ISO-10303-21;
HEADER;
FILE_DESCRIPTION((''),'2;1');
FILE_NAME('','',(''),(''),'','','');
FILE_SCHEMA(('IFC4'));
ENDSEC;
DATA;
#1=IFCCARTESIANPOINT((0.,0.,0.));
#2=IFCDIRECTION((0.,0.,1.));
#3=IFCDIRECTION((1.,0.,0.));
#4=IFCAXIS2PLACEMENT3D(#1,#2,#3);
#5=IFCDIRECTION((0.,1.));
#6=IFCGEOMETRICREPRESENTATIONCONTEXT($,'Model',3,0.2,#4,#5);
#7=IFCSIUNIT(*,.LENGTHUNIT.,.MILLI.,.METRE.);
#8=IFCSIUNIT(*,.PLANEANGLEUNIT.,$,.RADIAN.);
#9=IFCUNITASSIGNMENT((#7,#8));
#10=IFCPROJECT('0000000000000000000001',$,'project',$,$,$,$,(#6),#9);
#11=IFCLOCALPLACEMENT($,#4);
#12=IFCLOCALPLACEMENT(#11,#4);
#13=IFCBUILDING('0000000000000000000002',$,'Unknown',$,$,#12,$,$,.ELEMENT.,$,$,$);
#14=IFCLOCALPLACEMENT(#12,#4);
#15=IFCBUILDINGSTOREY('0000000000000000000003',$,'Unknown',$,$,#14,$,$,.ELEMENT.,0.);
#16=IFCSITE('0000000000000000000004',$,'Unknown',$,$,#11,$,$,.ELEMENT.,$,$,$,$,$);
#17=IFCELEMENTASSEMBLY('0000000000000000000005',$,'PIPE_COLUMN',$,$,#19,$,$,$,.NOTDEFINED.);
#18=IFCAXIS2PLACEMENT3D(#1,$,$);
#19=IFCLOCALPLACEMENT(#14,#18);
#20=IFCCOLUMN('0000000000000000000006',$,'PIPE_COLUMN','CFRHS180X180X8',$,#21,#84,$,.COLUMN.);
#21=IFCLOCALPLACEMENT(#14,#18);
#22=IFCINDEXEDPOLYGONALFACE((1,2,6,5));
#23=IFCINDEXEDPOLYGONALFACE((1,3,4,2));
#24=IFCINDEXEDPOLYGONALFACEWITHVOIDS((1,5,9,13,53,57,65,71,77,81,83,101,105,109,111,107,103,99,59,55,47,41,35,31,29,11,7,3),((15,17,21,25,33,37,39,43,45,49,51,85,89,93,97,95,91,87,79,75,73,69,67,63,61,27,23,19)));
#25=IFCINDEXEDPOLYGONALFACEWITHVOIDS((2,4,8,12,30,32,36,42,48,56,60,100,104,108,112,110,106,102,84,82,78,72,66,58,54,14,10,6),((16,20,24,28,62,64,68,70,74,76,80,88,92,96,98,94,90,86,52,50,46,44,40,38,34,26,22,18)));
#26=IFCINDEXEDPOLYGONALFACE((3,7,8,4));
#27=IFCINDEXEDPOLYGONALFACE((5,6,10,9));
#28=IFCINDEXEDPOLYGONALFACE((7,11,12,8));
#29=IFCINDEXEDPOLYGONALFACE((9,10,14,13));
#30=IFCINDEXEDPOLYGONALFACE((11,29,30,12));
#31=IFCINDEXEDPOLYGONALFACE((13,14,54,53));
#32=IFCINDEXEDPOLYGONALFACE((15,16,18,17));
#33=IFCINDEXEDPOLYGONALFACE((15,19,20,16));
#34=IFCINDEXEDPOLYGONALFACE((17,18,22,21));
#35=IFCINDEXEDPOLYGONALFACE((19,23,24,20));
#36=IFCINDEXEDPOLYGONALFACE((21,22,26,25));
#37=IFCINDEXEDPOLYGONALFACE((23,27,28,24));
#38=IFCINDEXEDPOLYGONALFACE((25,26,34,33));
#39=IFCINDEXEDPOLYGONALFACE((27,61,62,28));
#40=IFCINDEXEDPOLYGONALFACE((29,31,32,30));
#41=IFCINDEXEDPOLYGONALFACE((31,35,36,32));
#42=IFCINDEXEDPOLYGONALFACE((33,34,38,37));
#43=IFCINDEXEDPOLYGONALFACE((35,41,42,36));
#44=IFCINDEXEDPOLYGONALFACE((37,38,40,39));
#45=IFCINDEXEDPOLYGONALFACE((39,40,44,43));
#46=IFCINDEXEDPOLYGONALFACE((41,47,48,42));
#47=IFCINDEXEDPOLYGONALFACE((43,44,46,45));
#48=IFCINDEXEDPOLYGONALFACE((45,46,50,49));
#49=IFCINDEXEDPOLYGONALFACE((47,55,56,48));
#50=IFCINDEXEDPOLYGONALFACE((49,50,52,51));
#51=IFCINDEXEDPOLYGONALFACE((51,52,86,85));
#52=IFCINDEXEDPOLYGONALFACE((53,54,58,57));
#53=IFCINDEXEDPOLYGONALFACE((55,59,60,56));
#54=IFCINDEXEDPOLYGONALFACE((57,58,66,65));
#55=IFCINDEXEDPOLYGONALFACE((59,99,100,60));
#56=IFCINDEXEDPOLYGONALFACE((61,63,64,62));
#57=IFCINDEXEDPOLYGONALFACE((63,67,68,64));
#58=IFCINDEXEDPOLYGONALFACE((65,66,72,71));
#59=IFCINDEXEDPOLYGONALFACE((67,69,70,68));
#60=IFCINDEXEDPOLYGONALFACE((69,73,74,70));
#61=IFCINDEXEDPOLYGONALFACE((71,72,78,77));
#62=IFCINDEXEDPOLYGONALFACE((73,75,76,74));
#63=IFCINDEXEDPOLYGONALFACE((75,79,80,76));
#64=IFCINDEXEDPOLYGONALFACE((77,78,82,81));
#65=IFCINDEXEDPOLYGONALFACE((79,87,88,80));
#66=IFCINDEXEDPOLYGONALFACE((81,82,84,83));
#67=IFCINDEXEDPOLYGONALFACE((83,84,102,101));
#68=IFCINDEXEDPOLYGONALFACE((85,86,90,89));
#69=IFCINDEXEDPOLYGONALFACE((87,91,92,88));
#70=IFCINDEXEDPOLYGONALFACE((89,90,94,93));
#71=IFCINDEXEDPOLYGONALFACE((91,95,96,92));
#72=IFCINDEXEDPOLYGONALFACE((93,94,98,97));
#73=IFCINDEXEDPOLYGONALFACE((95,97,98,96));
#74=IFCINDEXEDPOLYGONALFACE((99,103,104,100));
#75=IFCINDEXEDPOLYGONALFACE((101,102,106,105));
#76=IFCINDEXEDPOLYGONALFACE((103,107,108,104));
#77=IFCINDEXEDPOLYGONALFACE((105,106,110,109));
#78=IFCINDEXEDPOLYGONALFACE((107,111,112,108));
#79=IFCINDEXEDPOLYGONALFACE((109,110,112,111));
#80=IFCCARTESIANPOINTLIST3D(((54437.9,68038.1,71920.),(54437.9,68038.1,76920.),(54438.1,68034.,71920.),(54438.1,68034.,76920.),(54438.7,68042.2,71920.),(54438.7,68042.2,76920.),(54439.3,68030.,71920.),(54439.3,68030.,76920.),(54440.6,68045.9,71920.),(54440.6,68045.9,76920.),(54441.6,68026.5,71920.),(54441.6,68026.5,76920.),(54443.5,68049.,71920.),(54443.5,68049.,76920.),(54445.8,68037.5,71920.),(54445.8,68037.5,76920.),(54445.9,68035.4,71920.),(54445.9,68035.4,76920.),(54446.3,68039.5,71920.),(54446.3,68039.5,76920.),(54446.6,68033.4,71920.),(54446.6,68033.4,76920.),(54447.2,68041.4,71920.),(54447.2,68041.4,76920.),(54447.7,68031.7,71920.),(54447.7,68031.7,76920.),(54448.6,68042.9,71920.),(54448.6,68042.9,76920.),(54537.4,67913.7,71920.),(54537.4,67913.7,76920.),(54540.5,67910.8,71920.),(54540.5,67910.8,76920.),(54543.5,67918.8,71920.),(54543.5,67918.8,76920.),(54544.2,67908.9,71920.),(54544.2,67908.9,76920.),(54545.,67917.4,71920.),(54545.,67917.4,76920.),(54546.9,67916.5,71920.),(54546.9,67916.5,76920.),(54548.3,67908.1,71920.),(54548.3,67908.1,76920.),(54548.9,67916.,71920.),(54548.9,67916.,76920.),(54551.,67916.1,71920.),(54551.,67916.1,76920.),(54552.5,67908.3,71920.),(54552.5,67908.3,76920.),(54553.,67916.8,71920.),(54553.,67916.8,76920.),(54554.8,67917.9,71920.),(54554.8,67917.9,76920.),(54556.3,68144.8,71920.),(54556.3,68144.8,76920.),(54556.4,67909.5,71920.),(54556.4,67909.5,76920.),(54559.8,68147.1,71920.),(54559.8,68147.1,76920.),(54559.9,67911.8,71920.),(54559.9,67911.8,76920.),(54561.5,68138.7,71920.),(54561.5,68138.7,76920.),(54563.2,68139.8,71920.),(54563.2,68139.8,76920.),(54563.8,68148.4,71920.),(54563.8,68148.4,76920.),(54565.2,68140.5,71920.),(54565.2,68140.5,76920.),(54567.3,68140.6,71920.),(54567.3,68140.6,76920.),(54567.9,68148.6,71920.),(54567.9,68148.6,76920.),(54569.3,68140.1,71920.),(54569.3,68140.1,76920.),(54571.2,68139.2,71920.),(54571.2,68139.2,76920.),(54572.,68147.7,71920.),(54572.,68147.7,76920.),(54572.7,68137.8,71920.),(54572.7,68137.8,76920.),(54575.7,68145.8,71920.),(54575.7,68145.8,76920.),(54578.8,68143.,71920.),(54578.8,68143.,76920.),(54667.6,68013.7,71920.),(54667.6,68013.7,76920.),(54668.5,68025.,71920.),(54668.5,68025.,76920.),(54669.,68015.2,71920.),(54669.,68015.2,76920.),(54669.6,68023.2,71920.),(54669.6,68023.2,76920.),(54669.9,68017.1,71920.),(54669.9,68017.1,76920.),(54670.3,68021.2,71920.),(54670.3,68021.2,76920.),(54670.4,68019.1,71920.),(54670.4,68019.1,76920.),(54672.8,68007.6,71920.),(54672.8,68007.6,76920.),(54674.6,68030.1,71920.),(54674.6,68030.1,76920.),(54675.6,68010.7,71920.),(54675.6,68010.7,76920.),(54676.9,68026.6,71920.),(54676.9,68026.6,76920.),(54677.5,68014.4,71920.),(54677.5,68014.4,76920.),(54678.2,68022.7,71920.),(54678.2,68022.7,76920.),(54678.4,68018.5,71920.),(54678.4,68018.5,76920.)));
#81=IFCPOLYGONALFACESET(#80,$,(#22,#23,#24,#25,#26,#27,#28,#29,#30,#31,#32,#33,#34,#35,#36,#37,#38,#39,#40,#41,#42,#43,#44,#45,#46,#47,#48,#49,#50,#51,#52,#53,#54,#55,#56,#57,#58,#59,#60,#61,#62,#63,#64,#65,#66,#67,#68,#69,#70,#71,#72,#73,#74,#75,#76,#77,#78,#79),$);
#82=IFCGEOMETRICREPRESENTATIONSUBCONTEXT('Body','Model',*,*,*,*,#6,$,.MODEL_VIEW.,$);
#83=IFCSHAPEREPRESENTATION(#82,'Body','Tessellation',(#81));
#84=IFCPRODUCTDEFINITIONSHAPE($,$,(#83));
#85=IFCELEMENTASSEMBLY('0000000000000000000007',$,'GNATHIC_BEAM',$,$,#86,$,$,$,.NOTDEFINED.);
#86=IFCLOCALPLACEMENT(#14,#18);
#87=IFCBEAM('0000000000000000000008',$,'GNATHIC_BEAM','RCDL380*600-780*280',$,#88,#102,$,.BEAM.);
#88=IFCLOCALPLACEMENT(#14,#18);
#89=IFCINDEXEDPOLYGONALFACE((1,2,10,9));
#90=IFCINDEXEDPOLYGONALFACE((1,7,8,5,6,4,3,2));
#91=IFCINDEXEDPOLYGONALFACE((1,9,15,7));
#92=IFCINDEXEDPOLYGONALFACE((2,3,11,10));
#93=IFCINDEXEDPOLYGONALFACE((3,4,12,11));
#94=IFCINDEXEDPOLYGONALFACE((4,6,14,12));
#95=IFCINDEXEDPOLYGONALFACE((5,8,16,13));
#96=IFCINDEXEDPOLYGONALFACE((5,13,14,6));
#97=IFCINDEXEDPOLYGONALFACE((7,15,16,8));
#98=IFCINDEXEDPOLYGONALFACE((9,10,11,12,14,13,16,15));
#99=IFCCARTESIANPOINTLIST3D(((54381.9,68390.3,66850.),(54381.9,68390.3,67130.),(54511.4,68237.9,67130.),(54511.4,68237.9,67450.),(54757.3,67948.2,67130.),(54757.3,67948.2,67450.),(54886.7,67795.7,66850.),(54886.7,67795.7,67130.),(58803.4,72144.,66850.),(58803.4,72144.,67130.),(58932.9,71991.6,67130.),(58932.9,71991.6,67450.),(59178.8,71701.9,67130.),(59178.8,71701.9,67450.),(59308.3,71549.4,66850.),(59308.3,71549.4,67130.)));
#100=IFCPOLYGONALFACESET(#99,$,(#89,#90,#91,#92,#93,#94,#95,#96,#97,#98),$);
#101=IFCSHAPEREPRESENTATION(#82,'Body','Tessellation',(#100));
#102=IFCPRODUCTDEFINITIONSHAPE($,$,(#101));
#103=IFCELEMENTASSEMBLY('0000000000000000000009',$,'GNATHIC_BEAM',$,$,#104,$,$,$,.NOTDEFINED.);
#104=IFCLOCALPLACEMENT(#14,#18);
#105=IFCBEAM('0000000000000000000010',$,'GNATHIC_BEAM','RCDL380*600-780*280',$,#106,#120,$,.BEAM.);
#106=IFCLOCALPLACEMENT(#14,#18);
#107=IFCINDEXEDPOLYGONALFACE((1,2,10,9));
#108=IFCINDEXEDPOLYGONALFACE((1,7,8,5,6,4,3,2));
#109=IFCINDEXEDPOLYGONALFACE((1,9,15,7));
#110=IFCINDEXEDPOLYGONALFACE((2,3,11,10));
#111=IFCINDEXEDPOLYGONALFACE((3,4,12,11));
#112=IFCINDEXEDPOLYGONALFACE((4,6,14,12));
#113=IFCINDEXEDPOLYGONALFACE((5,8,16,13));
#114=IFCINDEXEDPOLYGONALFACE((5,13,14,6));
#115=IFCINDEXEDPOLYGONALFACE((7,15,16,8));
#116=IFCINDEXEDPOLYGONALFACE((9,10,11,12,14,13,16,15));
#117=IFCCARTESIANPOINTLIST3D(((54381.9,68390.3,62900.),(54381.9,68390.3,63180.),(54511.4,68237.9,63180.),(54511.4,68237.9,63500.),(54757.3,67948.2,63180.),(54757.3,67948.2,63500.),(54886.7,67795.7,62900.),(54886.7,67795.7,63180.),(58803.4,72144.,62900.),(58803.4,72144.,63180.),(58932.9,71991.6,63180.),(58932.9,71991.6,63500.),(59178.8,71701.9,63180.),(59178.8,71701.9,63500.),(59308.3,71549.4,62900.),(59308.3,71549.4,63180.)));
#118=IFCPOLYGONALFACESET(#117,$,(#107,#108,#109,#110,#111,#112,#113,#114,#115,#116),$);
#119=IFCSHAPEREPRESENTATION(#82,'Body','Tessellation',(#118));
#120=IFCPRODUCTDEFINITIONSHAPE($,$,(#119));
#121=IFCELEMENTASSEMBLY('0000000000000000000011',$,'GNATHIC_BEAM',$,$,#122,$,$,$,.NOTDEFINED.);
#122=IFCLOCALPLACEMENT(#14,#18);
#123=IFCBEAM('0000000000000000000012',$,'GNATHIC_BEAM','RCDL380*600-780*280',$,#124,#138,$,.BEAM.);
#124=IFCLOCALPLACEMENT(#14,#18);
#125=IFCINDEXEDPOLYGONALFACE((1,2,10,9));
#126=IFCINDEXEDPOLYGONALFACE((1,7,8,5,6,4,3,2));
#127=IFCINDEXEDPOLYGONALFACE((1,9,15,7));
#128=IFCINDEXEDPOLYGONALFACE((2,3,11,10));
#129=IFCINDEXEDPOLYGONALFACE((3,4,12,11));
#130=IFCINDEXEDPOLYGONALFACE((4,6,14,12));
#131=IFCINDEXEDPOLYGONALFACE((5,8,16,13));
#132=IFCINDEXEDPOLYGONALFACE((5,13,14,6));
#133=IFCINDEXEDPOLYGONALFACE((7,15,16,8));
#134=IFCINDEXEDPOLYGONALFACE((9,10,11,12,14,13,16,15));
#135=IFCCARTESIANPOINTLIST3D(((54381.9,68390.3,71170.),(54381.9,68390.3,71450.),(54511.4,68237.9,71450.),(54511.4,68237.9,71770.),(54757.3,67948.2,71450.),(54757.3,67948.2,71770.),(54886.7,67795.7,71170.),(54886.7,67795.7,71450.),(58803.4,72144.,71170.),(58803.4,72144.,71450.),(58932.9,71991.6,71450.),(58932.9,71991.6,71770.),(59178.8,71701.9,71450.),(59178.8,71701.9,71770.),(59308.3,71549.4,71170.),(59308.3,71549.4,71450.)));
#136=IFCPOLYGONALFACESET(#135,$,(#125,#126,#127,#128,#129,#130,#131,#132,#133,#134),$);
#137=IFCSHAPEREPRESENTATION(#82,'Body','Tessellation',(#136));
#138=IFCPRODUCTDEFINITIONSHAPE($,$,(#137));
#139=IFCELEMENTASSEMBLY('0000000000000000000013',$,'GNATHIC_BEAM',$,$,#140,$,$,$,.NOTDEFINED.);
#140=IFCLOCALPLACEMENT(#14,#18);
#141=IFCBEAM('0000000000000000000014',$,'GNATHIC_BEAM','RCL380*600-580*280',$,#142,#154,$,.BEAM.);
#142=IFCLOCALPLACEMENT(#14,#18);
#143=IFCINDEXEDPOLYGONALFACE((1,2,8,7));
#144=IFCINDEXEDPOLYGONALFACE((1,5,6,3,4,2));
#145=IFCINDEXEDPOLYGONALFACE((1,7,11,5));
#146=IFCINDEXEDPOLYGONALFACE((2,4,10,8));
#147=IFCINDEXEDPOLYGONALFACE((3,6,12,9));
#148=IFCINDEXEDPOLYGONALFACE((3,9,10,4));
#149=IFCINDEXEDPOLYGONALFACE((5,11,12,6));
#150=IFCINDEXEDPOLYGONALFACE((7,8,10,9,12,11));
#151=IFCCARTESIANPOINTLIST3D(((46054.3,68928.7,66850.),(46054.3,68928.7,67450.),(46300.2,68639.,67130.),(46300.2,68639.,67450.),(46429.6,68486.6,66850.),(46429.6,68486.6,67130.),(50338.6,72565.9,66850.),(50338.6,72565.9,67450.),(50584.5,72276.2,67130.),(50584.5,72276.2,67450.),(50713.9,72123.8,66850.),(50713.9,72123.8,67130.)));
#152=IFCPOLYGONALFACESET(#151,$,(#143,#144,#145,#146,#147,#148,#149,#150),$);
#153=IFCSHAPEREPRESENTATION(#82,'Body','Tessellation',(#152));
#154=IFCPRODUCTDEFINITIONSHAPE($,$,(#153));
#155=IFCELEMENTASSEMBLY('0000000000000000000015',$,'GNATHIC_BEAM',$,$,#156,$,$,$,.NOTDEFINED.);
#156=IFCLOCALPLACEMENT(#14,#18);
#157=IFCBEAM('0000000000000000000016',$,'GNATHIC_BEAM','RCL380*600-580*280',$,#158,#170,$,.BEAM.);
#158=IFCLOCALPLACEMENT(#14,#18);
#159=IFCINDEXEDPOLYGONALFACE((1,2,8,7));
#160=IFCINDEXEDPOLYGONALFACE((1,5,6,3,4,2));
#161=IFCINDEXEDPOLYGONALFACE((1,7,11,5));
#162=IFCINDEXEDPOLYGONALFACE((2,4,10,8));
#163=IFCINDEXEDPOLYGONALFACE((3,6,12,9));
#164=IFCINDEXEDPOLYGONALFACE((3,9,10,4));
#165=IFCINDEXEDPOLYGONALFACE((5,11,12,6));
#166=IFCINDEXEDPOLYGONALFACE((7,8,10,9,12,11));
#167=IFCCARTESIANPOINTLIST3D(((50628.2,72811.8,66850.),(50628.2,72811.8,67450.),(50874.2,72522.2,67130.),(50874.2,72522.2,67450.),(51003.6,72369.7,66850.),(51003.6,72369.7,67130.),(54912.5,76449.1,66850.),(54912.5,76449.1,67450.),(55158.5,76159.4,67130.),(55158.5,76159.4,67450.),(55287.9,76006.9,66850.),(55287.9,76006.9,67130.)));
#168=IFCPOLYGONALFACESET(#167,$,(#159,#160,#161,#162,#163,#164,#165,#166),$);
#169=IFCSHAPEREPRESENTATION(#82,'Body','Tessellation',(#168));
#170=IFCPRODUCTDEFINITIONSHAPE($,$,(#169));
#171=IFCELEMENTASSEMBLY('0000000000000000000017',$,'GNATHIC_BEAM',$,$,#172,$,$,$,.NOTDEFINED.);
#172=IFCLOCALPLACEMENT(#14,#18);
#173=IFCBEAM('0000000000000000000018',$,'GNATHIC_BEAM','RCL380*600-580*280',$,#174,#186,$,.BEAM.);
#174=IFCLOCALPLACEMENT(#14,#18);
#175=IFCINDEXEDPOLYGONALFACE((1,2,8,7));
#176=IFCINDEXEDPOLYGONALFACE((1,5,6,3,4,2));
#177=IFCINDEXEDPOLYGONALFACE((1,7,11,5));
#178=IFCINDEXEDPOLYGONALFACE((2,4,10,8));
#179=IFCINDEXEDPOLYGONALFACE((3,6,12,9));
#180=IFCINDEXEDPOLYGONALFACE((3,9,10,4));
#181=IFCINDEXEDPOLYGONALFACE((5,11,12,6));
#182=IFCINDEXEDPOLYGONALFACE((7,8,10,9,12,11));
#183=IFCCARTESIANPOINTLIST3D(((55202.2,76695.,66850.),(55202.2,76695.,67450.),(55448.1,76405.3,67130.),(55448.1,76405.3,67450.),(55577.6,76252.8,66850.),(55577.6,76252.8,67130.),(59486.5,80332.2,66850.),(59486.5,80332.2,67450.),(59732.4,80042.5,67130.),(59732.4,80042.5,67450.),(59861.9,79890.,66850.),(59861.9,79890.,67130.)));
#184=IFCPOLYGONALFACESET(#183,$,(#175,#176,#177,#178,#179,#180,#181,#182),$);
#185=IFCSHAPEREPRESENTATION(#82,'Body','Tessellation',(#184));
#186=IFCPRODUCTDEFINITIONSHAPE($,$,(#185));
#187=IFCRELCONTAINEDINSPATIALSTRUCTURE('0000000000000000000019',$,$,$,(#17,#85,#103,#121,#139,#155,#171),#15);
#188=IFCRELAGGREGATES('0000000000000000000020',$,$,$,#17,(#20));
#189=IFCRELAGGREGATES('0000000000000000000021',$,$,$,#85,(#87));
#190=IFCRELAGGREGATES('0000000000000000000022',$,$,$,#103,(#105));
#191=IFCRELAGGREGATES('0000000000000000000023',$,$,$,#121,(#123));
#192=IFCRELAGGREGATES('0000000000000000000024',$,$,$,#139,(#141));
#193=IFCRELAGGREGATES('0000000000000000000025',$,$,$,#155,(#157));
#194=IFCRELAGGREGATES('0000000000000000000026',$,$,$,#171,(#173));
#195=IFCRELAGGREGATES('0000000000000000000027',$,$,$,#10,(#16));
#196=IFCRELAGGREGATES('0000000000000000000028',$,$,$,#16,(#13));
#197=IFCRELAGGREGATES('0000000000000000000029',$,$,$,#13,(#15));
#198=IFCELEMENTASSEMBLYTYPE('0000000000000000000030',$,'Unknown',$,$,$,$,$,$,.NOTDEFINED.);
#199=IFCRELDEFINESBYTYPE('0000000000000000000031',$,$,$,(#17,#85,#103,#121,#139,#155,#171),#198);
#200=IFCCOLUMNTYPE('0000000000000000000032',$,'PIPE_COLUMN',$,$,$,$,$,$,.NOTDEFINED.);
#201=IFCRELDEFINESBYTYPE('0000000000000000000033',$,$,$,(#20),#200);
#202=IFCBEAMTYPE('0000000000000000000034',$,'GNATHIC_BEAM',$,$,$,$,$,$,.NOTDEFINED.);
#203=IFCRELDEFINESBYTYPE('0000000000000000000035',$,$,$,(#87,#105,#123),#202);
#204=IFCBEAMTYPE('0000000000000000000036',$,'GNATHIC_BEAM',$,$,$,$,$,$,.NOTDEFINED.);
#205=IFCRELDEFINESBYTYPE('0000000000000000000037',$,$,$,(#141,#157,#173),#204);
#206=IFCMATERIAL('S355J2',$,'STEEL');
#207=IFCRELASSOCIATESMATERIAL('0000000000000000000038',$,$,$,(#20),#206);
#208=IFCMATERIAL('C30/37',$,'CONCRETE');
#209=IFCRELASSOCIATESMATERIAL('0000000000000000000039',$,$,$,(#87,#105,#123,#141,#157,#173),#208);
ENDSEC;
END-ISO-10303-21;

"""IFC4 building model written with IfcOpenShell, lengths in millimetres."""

from ifc_helpers import new_model, si_unit, direction, frame, origin_with_axes, origin_2d_with_axis, place, context, subcontext, project, spatial, polyline, hollow_rectangle, outline, extrude, material, material_profile, profile_set, profile_usage, type_object, element, aggregate, save


model = new_model("IFC4")

# Units and contexts
model_context = context("Model", 3, precision=0.2, world=origin_with_axes(), true_north=direction((0.0, 1.0)))
body_context = subcontext(model_context, "Body", "Model", "MODEL_VIEW")
ifc_project = project(units=[si_unit("LENGTHUNIT", "METRE", prefix="MILLI"), si_unit("PLANEANGLEUNIT", "RADIAN")], contexts=[model_context])

# Site, building, storey
site_placement = place(None, origin_with_axes())
site = spatial("IfcSite", under=ifc_project, at=site_placement, Name="Unknown", CompositionType="ELEMENT")
building_placement = place(site_placement, origin_with_axes())
building = spatial("IfcBuilding", under=site, at=building_placement, Name="Unknown", CompositionType="ELEMENT")
storey_placement = place(building_placement, origin_with_axes())
storey = spatial("IfcBuildingStorey", under=building, at=storey_placement, Name="Unknown", CompositionType="ELEMENT", Elevation=0.0)

# Element assembly, column
element_assembly_type = type_object("IfcElementAssemblyType", Name="Unknown", PredefinedType="NOTDEFINED")
ifc_material_1 = material(Name="S355J2", Category="STEEL")
ifc_material_profile_1 = material_profile(ifc_material_1, hollow_rectangle(XDim=180.0, YDim=180.0, WallThickness=8.0, InnerFilletRadius=8.0, OuterFilletRadius=16.0, at=origin_2d_with_axis()), Name="CFRHS180X180X8")
ifc_profile_set_1 = profile_set([ifc_material_profile_1])
column_type_1 = type_object("IfcColumnType", Name="PIPE_COLUMN")
assembly_1_placement = place(storey_placement, frame((54558.1, 68028.3, 71920.0), z_axis=(-0.762329, -0.64719, 0.0), x_axis=(0.0, 0.0, 1.0)))
assembly_1 = element("IfcElementAssembly", 1, at=assembly_1_placement, inside=storey, type_object=element_assembly_type, Name="PIPE_COLUMN", PredefinedType="NOTDEFINED")
ifc_profile_usage_1 = profile_usage(ifc_profile_set_1, cardinal=8)
column_1_placement = place(assembly_1_placement, origin_with_axes())
column_1 = element("IfcColumn", 2, at=column_1_placement, type_object=column_type_1, material=ifc_profile_usage_1, Name="PIPE_COLUMN", Description="CFRHS180X180X8", PredefinedType="COLUMN", context=body_context, shape_type="SolidModel", body=[
    extrude(hollow_rectangle(XDim=180.0, YDim=180.0, WallThickness=8.0, InnerFilletRadius=8.0, OuterFilletRadius=16.0, at=origin_2d_with_axis()), frame((0.0, 0.0, 0.0), z_axis=(-1.0, 0.0, 0.0), x_axis=(0.0, 0.0, 1.0)), (0.0, 0.0, -1.0), 5000.0),
])
aggregate(assembly_1, [column_1])

# Element assemblies, beams
assembly_2_placement = place(storey_placement, frame((54634.3, 68093.0, 67150.0), z_axis=(0.64719, -0.762329, 0.0), x_axis=(0.762329, 0.64719, 0.0)))
assembly_2 = element("IfcElementAssembly", 3, at=assembly_2_placement, inside=storey, type_object=element_assembly_type, Name="GNATHIC_BEAM", PredefinedType="NOTDEFINED")
ifc_material_2 = material(Name="C30/37", Category="CONCRETE")
ifc_material_profile_2 = material_profile(ifc_material_2, outline(polyline([(-390.0, -300.0), (390.0, -300.0), (390.0, -20.0), (190.0, -20.0), (190.0, 300.0), (-190.0, 300.0), (-190.0, -20.0), (-390.0, -20.0), (-390.0, -300.0)])), Name="RCDL380*600-780*280")
ifc_profile_set_2 = profile_set([ifc_material_profile_2])
ifc_profile_usage_2 = profile_usage(ifc_profile_set_2, cardinal=2)
beam_type_1 = type_object("IfcBeamType", Name="GNATHIC_BEAM")
beam_1_placement = place(assembly_2_placement, origin_with_axes())
beam_1 = element("IfcBeam", 4, at=beam_1_placement, type_object=beam_type_1, material=ifc_profile_usage_2, Name="GNATHIC_BEAM", Description="RCDL380*600-780*280", PredefinedType="BEAM", context=body_context, shape_type="SolidModel", body=[
    extrude(outline(polyline([(-390.0, -300.0), (390.0, -300.0), (390.0, -20.0), (190.0, -20.0), (190.0, 300.0), (-190.0, 300.0), (-190.0, -20.0), (-390.0, -20.0), (-390.0, -300.0)])), frame((0.0, 0.0, 0.0), z_axis=(-1.0, 0.0, 0.0), x_axis=(0.0, 0.0, 1.0)), (0.0, 0.0, -1.0), 5800.0),
])
aggregate(assembly_2, [beam_1])
assembly_3_placement = place(storey_placement, frame((54634.3, 68093.0, 63200.0), z_axis=(0.64719, -0.762329, 0.0), x_axis=(0.762329, 0.64719, 0.0)))
assembly_3 = element("IfcElementAssembly", 5, at=assembly_3_placement, inside=storey, type_object=element_assembly_type, Name="GNATHIC_BEAM", PredefinedType="NOTDEFINED")
beam_2_placement = place(assembly_3_placement, origin_with_axes())
beam_2 = element("IfcBeam", 6, at=beam_2_placement, type_object=beam_type_1, material=ifc_profile_usage_2, Name="GNATHIC_BEAM", Description="RCDL380*600-780*280", PredefinedType="BEAM", context=body_context, shape_type="SolidModel", body=[
    extrude(outline(polyline([(-390.0, -300.0), (390.0, -300.0), (390.0, -20.0), (190.0, -20.0), (190.0, 300.0), (-190.0, 300.0), (-190.0, -20.0), (-390.0, -20.0), (-390.0, -300.0)])), frame((0.0, 0.0, 0.0), z_axis=(-1.0, 0.0, 0.0), x_axis=(0.0, 0.0, 1.0)), (0.0, 0.0, -1.0), 5800.0),
])
aggregate(assembly_3, [beam_2])
assembly_4_placement = place(storey_placement, frame((54634.3, 68093.0, 71470.0), z_axis=(0.64719, -0.762329, 0.0), x_axis=(0.762329, 0.64719, 0.0)))
assembly_4 = element("IfcElementAssembly", 7, at=assembly_4_placement, inside=storey, type_object=element_assembly_type, Name="GNATHIC_BEAM", PredefinedType="NOTDEFINED")
beam_3_placement = place(assembly_4_placement, origin_with_axes())
beam_3 = element("IfcBeam", 8, at=beam_3_placement, type_object=beam_type_1, material=ifc_profile_usage_2, Name="GNATHIC_BEAM", Description="RCDL380*600-780*280", PredefinedType="BEAM", context=body_context, shape_type="SolidModel", body=[
    extrude(outline(polyline([(-390.0, -300.0), (390.0, -300.0), (390.0, -20.0), (190.0, -20.0), (190.0, 300.0), (-190.0, 300.0), (-190.0, -20.0), (-390.0, -20.0), (-390.0, -300.0)])), frame((0.0, 0.0, 0.0), z_axis=(-1.0, 0.0, 0.0), x_axis=(0.0, 0.0, 1.0)), (0.0, 0.0, -1.0), 5800.0),
])
aggregate(assembly_4, [beam_3])
assembly_5_placement = place(storey_placement, frame((46177.2, 68783.9, 67150.0), z_axis=(0.64719, -0.762329, 0.0), x_axis=(0.762329, 0.64719, 0.0)))
assembly_5 = element("IfcElementAssembly", 9, at=assembly_5_placement, inside=storey, type_object=element_assembly_type, Name="GNATHIC_BEAM", PredefinedType="NOTDEFINED")
ifc_material_profile_3 = material_profile(ifc_material_2, outline(polyline([(-190.0, -300.0), (390.0, -300.0), (390.0, -20.0), (190.0, -20.0), (190.0, 300.0), (-190.0, 300.0), (-190.0, -300.0)])), Name="RCL380*600-580*280")
ifc_profile_set_3 = profile_set([ifc_material_profile_3])
ifc_profile_usage_3 = profile_usage(ifc_profile_set_3, cardinal=2)
beam_type_2 = type_object("IfcBeamType", Name="GNATHIC_BEAM")
beam_4_placement = place(assembly_5_placement, origin_with_axes())
beam_4 = element("IfcBeam", 10, at=beam_4_placement, type_object=beam_type_2, material=ifc_profile_usage_3, Name="GNATHIC_BEAM", Description="RCL380*600-580*280", PredefinedType="BEAM", context=body_context, shape_type="SolidModel", body=[
    extrude(outline(polyline([(-190.0, -300.0), (390.0, -300.0), (390.0, -20.0), (190.0, -20.0), (190.0, 300.0), (-190.0, 300.0), (-190.0, -300.0)])), frame((0.0, 0.0, 0.0), z_axis=(-1.0, 0.0, 0.0), x_axis=(0.0, 0.0, 1.0)), (0.0, 0.0, -1.0), 5620.0),
])
aggregate(assembly_5, [beam_4])
assembly_6_placement = place(storey_placement, frame((50751.2, 72667.0, 67150.0), z_axis=(0.64719, -0.762329, 0.0), x_axis=(0.762329, 0.64719, 0.0)))
assembly_6 = element("IfcElementAssembly", 11, at=assembly_6_placement, inside=storey, type_object=element_assembly_type, Name="GNATHIC_BEAM", PredefinedType="NOTDEFINED")
beam_5_placement = place(assembly_6_placement, origin_with_axes())
beam_5 = element("IfcBeam", 12, at=beam_5_placement, type_object=beam_type_2, material=ifc_profile_usage_3, Name="GNATHIC_BEAM", Description="RCL380*600-580*280", PredefinedType="BEAM", context=body_context, shape_type="SolidModel", body=[
    extrude(outline(polyline([(-190.0, -300.0), (390.0, -300.0), (390.0, -20.0), (190.0, -20.0), (190.0, 300.0), (-190.0, 300.0), (-190.0, -300.0)])), frame((0.0, 0.0, 0.0), z_axis=(-1.0, 0.0, 0.0), x_axis=(0.0, 0.0, 1.0)), (0.0, 0.0, -1.0), 5620.0),
])
aggregate(assembly_6, [beam_5])
assembly_7_placement = place(storey_placement, frame((55325.2, 76550.1, 67150.0), z_axis=(0.64719, -0.762329, 0.0), x_axis=(0.762329, 0.64719, 0.0)))
assembly_7 = element("IfcElementAssembly", 13, at=assembly_7_placement, inside=storey, type_object=element_assembly_type, Name="GNATHIC_BEAM", PredefinedType="NOTDEFINED")
beam_6_placement = place(assembly_7_placement, origin_with_axes())
beam_6 = element("IfcBeam", 14, at=beam_6_placement, type_object=beam_type_2, material=ifc_profile_usage_3, Name="GNATHIC_BEAM", Description="RCL380*600-580*280", PredefinedType="BEAM", context=body_context, shape_type="SolidModel", body=[
    extrude(outline(polyline([(-190.0, -300.0), (390.0, -300.0), (390.0, -20.0), (190.0, -20.0), (190.0, 300.0), (-190.0, 300.0), (-190.0, -300.0)])), frame((0.0, 0.0, 0.0), z_axis=(-1.0, 0.0, 0.0), x_axis=(0.0, 0.0, 1.0)), (0.0, 0.0, -1.0), 5620.0),
])
aggregate(assembly_7, [beam_6])

save(model, "model.ifc")
